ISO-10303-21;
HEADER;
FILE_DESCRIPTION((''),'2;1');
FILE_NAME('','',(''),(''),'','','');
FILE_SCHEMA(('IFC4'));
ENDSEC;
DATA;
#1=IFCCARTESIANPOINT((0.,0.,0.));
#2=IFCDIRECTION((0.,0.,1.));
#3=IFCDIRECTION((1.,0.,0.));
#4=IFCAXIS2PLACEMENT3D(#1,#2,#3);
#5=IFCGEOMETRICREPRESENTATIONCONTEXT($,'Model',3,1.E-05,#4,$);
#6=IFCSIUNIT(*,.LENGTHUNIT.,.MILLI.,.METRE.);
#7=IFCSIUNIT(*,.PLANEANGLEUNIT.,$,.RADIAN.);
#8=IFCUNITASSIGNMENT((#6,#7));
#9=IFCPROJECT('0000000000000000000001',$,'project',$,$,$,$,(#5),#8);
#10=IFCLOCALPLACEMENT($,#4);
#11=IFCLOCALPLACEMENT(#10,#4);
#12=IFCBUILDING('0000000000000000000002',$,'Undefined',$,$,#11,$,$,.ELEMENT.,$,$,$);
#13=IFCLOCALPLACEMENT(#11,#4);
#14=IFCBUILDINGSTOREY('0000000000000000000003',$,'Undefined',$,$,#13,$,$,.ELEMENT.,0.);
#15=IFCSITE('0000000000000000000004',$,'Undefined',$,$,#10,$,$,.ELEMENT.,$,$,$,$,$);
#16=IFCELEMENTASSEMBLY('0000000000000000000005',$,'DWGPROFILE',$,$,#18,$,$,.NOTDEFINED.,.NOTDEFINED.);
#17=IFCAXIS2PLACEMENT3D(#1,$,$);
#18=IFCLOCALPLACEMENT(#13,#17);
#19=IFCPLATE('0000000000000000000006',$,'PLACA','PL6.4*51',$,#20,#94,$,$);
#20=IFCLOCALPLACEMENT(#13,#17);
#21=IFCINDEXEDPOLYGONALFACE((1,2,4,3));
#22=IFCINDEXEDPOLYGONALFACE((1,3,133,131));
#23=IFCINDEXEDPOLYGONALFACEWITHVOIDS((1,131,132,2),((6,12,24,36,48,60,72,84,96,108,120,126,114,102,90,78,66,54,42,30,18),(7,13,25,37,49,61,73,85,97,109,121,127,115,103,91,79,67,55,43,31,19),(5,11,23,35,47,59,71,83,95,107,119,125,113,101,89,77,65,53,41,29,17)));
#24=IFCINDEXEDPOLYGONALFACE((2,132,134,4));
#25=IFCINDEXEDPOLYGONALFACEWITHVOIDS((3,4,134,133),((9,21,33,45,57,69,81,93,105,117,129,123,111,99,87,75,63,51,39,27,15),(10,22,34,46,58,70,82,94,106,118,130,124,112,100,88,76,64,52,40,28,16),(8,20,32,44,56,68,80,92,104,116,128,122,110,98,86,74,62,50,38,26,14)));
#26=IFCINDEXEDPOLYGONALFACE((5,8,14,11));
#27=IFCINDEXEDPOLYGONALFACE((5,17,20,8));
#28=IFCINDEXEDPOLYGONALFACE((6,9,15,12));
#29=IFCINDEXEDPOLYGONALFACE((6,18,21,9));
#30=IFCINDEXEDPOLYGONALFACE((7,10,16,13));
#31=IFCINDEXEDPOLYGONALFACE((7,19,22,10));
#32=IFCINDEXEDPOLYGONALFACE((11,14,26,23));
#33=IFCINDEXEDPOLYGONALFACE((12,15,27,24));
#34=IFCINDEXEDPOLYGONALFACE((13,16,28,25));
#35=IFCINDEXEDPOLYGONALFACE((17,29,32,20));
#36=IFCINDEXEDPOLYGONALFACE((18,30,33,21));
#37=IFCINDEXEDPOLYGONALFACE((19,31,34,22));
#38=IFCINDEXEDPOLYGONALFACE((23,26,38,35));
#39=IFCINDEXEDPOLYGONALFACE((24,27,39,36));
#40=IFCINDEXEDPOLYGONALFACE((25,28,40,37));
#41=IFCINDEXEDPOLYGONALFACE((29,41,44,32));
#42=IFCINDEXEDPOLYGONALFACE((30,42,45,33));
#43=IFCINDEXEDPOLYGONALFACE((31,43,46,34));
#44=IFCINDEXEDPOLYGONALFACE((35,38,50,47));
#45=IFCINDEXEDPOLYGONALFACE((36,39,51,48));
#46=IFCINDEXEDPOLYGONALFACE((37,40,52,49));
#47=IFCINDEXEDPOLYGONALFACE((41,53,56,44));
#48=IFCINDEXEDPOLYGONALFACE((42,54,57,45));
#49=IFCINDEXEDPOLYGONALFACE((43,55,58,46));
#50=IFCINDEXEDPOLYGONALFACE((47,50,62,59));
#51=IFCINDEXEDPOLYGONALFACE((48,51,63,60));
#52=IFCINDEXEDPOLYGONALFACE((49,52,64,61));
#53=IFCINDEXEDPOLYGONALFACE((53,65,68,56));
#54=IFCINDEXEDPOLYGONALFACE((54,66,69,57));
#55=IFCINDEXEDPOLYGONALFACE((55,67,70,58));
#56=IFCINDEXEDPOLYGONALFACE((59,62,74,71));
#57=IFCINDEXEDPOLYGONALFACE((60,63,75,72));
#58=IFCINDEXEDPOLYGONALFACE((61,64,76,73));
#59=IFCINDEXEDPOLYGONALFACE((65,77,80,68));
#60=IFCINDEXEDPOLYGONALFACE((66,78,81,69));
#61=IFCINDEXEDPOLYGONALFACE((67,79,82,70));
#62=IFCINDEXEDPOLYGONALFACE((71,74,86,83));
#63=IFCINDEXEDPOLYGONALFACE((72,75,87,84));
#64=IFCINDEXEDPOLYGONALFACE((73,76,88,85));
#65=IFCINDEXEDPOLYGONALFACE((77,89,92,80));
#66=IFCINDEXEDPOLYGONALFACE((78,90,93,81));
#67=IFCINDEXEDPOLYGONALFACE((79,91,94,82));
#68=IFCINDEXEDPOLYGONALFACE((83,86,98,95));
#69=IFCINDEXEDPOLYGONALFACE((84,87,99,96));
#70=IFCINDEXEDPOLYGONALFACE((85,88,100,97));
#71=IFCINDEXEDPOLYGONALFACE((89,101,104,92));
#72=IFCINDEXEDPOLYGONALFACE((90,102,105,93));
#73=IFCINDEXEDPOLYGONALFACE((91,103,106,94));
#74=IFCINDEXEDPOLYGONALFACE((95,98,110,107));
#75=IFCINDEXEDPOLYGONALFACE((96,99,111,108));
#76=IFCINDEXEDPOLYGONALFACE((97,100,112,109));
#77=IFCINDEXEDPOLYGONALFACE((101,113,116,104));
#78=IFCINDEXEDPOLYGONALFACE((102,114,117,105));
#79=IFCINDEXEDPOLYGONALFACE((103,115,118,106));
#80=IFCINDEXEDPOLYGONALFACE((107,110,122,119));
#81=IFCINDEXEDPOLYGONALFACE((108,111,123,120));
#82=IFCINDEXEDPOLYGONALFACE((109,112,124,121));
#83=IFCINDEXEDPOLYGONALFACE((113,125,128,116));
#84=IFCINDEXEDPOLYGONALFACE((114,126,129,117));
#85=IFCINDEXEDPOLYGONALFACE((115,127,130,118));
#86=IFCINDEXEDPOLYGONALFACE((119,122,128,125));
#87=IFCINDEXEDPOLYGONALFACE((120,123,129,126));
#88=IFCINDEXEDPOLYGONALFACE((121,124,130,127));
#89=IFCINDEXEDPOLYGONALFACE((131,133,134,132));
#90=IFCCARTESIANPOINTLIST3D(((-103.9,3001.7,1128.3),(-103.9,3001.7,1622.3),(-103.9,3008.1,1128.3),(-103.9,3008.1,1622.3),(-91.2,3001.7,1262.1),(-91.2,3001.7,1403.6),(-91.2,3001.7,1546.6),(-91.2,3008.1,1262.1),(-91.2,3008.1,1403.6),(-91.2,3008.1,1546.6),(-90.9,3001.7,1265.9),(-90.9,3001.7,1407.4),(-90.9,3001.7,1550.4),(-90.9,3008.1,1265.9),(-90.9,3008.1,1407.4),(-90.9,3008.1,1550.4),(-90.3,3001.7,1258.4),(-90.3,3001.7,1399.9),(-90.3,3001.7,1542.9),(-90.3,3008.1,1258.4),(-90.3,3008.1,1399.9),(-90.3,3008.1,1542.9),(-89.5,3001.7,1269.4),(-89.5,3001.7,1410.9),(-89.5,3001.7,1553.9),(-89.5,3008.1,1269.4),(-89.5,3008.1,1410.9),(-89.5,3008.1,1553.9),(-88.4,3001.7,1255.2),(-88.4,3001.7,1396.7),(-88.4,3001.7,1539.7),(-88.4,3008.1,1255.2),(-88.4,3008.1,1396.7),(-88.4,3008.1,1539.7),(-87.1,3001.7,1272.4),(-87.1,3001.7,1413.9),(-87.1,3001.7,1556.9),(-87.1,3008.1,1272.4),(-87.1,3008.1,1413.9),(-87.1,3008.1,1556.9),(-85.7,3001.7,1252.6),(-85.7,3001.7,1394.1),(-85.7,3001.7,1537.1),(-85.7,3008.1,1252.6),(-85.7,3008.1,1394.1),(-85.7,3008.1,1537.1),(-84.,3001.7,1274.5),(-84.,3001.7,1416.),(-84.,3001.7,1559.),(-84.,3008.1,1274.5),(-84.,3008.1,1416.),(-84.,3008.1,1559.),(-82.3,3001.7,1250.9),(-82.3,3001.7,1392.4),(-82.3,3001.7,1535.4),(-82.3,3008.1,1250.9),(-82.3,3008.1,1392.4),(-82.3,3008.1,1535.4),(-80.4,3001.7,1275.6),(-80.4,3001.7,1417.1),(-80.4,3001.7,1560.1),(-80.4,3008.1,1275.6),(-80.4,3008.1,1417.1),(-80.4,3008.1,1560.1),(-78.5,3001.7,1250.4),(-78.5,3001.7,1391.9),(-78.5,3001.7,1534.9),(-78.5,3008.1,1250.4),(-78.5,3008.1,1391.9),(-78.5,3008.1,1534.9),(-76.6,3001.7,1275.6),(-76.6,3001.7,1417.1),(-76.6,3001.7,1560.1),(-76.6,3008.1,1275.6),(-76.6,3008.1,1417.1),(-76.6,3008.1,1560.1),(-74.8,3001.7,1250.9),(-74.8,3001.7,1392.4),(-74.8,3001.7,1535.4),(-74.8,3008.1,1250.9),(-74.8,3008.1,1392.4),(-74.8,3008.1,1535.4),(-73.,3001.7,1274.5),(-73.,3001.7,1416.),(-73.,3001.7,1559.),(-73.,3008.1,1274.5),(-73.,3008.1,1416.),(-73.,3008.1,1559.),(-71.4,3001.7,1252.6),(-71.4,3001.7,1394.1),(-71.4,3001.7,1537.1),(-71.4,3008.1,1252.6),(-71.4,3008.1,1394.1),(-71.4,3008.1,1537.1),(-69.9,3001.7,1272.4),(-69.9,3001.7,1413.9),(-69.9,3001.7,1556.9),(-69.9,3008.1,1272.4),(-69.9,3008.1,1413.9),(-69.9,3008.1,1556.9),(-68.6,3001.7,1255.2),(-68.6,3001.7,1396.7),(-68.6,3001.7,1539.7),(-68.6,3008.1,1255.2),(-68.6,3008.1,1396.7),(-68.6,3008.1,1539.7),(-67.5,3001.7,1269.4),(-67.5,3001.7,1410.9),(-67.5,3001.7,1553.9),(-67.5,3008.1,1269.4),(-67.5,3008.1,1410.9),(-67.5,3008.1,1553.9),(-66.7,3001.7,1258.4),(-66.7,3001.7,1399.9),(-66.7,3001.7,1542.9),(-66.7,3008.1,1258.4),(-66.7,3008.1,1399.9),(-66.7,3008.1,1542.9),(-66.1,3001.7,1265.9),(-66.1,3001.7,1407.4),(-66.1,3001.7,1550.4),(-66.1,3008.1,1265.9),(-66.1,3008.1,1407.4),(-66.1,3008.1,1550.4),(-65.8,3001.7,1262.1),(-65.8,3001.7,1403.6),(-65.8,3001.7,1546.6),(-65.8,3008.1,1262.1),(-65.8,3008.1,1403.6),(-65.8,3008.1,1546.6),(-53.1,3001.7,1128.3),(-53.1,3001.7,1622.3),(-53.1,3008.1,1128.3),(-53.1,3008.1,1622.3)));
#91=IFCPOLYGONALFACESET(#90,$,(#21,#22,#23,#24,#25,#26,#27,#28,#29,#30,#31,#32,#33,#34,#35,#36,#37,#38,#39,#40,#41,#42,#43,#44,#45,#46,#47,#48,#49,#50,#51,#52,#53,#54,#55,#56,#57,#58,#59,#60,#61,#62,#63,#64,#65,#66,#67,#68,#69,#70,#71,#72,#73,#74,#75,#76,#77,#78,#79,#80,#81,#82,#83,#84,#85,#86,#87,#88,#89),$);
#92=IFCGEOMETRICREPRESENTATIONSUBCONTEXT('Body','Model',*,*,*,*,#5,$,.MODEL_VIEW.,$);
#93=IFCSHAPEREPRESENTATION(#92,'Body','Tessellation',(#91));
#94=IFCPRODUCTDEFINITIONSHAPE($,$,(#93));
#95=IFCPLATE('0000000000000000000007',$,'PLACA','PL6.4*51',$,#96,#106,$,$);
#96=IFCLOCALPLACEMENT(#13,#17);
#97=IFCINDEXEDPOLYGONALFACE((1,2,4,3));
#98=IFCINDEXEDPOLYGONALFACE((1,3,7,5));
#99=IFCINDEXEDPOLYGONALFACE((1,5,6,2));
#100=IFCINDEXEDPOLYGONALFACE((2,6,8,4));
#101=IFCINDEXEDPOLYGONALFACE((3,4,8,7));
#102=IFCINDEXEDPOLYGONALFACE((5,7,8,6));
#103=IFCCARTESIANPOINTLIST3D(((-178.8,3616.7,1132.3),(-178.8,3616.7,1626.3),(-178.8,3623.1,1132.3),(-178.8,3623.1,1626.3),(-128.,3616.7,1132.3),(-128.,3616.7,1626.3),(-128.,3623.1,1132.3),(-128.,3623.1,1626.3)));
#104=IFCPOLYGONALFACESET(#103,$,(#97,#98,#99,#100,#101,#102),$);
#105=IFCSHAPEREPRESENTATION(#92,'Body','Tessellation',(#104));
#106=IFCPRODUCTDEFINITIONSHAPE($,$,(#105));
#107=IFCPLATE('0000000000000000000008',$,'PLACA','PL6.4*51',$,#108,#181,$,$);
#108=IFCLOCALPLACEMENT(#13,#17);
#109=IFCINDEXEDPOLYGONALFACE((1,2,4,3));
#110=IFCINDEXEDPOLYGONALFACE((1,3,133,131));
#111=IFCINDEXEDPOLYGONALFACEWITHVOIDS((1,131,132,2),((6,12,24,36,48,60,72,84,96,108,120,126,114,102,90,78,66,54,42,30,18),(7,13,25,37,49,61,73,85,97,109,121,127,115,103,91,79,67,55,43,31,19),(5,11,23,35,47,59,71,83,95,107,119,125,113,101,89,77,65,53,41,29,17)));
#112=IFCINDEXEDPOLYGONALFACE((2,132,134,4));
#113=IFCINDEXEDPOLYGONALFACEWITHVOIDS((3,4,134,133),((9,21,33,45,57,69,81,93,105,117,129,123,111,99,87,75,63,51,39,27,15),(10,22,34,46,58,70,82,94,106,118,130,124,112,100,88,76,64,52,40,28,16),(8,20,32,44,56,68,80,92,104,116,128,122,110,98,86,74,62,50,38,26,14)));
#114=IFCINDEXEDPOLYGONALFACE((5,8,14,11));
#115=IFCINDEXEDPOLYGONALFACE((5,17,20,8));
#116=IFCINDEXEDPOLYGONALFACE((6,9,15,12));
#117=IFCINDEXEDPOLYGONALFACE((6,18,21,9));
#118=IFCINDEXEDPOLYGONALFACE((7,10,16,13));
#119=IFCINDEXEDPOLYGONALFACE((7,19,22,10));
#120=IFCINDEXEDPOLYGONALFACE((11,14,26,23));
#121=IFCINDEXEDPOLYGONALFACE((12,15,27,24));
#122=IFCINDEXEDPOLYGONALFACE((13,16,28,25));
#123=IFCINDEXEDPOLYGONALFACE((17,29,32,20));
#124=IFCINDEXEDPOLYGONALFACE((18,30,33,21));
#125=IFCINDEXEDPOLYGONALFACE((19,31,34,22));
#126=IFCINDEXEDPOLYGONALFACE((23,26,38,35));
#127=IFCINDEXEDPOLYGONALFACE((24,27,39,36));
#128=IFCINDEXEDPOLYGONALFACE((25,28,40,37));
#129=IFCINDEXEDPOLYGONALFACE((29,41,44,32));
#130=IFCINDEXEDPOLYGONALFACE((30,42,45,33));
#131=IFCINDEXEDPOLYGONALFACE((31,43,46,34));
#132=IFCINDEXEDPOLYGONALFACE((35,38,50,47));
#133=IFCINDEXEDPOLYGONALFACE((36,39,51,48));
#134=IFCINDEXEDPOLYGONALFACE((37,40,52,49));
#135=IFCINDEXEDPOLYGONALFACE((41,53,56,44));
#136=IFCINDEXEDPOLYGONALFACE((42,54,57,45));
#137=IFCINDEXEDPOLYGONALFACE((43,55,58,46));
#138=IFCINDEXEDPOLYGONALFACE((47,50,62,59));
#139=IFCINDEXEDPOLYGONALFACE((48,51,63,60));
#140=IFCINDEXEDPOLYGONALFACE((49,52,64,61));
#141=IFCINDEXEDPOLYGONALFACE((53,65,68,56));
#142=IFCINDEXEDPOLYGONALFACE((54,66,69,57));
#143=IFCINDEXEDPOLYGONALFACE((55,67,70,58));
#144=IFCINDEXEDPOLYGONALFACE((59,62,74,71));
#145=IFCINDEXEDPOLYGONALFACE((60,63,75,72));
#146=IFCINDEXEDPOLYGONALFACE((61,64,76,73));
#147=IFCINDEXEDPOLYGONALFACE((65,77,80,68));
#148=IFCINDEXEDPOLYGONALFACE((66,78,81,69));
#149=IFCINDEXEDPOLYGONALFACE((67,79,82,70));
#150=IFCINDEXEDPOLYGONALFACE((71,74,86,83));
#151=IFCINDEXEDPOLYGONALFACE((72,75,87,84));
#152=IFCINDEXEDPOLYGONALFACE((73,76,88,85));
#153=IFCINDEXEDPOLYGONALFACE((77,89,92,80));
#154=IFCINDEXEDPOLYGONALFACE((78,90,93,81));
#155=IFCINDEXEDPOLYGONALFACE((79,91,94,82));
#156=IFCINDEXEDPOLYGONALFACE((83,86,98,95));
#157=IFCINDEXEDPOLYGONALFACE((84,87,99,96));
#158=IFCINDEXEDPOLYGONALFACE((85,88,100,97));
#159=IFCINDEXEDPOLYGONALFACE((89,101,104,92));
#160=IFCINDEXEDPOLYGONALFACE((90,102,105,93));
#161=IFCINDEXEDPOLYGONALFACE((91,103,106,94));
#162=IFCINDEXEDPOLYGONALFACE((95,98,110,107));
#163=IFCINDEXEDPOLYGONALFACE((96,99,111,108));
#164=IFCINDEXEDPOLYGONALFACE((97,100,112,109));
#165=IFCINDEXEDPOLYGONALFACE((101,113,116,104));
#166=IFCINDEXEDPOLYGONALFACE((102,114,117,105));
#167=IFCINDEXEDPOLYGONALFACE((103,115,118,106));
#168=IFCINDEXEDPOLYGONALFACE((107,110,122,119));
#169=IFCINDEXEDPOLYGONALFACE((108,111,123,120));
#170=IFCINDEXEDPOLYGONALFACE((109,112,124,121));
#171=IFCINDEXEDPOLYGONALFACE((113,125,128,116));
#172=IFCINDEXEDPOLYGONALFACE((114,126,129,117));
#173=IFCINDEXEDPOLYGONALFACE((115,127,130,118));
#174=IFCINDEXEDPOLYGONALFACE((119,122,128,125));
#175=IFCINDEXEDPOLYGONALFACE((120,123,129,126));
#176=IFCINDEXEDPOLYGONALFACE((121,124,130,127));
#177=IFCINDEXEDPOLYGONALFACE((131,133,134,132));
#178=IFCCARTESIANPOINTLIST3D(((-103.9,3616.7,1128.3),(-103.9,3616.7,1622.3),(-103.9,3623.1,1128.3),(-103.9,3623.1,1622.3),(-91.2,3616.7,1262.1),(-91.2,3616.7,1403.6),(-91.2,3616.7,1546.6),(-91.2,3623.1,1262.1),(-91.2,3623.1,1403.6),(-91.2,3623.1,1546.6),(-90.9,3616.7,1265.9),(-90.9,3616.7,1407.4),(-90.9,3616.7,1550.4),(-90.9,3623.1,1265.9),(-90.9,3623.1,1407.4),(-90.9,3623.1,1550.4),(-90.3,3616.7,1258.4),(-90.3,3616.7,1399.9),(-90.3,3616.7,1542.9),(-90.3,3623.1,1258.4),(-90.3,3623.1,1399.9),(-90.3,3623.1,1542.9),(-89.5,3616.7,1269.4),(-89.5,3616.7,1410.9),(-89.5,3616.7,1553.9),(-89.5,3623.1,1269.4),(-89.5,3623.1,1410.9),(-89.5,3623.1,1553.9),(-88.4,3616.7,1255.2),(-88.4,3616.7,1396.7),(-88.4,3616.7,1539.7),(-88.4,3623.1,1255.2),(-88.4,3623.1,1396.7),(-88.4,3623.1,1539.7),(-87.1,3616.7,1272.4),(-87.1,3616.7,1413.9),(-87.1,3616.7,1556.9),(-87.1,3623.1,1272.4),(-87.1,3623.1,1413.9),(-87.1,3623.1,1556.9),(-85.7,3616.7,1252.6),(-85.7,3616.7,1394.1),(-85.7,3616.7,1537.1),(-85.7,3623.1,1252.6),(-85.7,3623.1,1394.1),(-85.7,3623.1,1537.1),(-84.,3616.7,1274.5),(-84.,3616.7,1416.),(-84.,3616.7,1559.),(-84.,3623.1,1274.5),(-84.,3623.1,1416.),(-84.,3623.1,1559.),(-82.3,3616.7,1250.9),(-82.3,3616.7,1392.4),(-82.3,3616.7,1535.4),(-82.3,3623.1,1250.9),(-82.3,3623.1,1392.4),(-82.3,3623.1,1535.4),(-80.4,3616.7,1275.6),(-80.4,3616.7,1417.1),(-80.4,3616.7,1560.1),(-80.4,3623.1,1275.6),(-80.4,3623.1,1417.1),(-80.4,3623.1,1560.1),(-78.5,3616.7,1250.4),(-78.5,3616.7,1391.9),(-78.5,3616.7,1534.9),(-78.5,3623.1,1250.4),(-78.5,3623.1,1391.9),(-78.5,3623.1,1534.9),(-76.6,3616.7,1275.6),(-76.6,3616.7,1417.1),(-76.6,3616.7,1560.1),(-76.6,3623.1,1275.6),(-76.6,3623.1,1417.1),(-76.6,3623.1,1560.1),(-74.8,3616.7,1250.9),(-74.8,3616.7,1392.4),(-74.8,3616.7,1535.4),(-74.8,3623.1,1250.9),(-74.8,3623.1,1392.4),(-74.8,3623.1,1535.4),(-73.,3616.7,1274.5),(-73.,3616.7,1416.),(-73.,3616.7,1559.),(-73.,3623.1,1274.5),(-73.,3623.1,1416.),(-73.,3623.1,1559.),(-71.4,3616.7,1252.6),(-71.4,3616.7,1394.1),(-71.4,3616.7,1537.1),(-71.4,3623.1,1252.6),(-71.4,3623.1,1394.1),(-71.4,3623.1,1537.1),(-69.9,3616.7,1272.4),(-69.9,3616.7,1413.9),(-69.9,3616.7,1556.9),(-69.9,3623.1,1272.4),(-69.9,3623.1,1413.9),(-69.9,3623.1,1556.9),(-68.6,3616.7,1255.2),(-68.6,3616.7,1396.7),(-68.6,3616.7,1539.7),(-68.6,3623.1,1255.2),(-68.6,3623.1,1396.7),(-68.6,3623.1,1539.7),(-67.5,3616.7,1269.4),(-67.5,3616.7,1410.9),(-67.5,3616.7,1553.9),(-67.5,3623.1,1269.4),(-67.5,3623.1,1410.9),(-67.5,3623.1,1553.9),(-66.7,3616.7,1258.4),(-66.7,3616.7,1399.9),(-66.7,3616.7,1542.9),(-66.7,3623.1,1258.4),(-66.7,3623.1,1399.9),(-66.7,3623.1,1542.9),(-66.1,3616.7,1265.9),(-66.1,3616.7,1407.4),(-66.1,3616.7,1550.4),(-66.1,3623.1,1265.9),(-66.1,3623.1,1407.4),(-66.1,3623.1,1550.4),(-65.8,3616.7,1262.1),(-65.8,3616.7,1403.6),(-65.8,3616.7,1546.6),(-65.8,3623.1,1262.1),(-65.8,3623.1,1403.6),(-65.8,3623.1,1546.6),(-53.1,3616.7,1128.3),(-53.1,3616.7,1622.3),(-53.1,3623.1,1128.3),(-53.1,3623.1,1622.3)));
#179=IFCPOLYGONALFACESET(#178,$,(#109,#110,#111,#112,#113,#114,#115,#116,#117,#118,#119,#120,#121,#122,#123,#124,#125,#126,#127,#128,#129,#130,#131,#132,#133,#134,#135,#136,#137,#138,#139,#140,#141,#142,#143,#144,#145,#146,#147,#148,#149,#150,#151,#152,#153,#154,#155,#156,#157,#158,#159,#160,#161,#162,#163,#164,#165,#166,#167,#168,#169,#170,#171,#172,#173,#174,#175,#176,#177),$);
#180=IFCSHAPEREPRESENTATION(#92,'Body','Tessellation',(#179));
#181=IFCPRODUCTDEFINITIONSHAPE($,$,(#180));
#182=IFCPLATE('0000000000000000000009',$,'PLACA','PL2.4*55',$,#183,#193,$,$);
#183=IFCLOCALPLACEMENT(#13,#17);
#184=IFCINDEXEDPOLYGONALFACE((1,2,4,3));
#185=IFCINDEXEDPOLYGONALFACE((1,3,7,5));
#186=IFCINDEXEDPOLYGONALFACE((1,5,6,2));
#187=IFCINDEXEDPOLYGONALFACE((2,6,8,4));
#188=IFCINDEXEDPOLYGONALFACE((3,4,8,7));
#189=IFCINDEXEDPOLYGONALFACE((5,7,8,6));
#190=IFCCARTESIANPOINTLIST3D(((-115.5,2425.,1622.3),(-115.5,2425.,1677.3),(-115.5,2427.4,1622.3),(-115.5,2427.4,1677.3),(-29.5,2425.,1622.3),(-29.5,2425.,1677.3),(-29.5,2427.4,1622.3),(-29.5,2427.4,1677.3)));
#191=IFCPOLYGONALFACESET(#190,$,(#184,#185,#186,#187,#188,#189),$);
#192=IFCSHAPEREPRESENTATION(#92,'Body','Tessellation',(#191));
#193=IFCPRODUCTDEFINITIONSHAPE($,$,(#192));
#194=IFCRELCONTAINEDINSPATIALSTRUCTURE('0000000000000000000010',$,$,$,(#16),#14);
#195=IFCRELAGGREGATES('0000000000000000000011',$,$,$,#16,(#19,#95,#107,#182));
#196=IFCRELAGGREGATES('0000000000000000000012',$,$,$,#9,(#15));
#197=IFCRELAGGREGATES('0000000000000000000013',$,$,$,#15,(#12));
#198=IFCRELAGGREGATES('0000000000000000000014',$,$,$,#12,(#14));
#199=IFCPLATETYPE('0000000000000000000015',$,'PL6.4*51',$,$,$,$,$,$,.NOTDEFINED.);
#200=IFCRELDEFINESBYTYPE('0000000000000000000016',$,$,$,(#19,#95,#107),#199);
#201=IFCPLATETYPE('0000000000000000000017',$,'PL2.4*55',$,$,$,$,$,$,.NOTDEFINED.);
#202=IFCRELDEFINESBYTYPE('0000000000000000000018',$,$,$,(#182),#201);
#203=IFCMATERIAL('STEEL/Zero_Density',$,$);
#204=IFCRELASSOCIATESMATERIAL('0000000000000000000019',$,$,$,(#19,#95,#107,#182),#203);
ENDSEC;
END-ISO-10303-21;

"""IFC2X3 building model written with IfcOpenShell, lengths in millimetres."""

from ifc_helpers import new_model, si_unit, frame, origin_with_axes, origin_2d_with_axis, place, context, subcontext, project, spatial, polyline, circle, outline, extrude, boolean, material, type_object, element, aggregate, save


model = new_model("IFC2X3")

# Units and contexts
model_context = context("Model", 3, precision=1e-05, world=origin_with_axes())
body_context = subcontext(model_context, "Body", "Model", "MODEL_VIEW")
ifc_project = project(units=[si_unit("LENGTHUNIT", "METRE", prefix="MILLI"), si_unit("PLANEANGLEUNIT", "RADIAN")], contexts=[model_context])

# Site, building, storey
site_placement = place(None, origin_with_axes())
site = spatial("IfcSite", under=ifc_project, at=site_placement, Name="Undefined", CompositionType="ELEMENT")
building_placement = place(site_placement, origin_with_axes())
building = spatial("IfcBuilding", under=site, at=building_placement, Name="Undefined", CompositionType="ELEMENT")
storey_placement = place(building_placement, origin_with_axes())
storey = spatial("IfcBuildingStorey", under=building, at=storey_placement, Name="Undefined", CompositionType="ELEMENT", Elevation=0.0)

# Element assembly, plates
assembly_1_placement = place(storey_placement, origin_with_axes())
assembly_1 = element("IfcElementAssembly", 1, at=assembly_1_placement, inside=storey, Name="DWGPROFILE", AssemblyPlace="NOTDEFINED", PredefinedType="NOTDEFINED")
ifc_material_1 = material(Name="STEEL/Zero_Density")
plate_type_1 = type_object("IfcPlateType", Name="PL6.4*51", PredefinedType="NOTDEFINED")
plate_1_placement = place(assembly_1_placement, frame((-53.1, 3004.9, 1622.3), z_axis=(0.0, -1.0, 0.0), x_axis=(-1.0, 0.0, 0.0)))
plate_1 = element("IfcPlate", 2, at=plate_1_placement, type_object=plate_type_1, material=ifc_material_1, Name="PLACA", Description="PL6.4*51", context=body_context, shape_type="CSG", body=[
    boolean("DIFFERENCE", boolean("DIFFERENCE", boolean("DIFFERENCE", extrude(outline(polyline([(0.0, 0.0), (50.8, 0.0), (50.8, 494.0), (0.0, 494.0), (0.0, 0.0)])), frame((0.0, 0.0, -3.2), z_axis=(0.0, 0.0, 1.0), x_axis=(1.0, 0.0, 0.0)), (0.0, 0.0, 1.0), 6.4), extrude(circle(Radius=12.7, at=origin_2d_with_axis()), frame((25.4, 74.7, -100.0), z_axis=(0.0, 0.0, 1.0), x_axis=(0.0, 1.0, 0.0)), (0.0, 0.0, 1.0), 200.0)), extrude(circle(Radius=12.7, at=origin_2d_with_axis()), frame((25.4, 217.7, -100.0), z_axis=(0.0, 0.0, 1.0), x_axis=(0.0, 1.0, 0.0)), (0.0, 0.0, 1.0), 200.0)), extrude(circle(Radius=12.7, at=origin_2d_with_axis()), frame((25.4, 359.2, -100.0), z_axis=(0.0, 0.0, 1.0), x_axis=(0.0, 1.0, 0.0)), (0.0, 0.0, 1.0), 200.0)),
])
plate_2_placement = place(assembly_1_placement, frame((-128.0, 3619.9, 1626.3), z_axis=(0.0, -1.0, 0.0), x_axis=(-1.0, 0.0, 0.0)))
plate_2 = element("IfcPlate", 3, at=plate_2_placement, type_object=plate_type_1, material=ifc_material_1, Name="PLACA", Description="PL6.4*51", context=body_context, shape_type="SweptSolid", body=[
    extrude(outline(polyline([(0.0, 0.0), (50.8, 0.0), (50.8, 494.0), (0.0, 494.0), (0.0, 0.0)])), frame((0.0, 0.0, -3.2), z_axis=(0.0, 0.0, 1.0), x_axis=(1.0, 0.0, 0.0)), (0.0, 0.0, 1.0), 6.4),
])
plate_3_placement = place(assembly_1_placement, frame((-53.1, 3619.9, 1622.3), z_axis=(0.0, -1.0, 0.0), x_axis=(-1.0, 0.0, 0.0)))
plate_3 = element("IfcPlate", 4, at=plate_3_placement, type_object=plate_type_1, material=ifc_material_1, Name="PLACA", Description="PL6.4*51", context=body_context, shape_type="CSG", body=[
    boolean("DIFFERENCE", boolean("DIFFERENCE", boolean("DIFFERENCE", extrude(outline(polyline([(0.0, 0.0), (50.8, 0.0), (50.8, 494.0), (0.0, 494.0), (0.0, 0.0)])), frame((0.0, 0.0, -3.2), z_axis=(0.0, 0.0, 1.0), x_axis=(1.0, 0.0, 0.0)), (0.0, 0.0, 1.0), 6.4), extrude(circle(Radius=12.7, at=origin_2d_with_axis()), frame((25.4, 74.7, -100.0), z_axis=(0.0, 0.0, 1.0), x_axis=(0.0, 1.0, 0.0)), (0.0, 0.0, 1.0), 200.0)), extrude(circle(Radius=12.7, at=origin_2d_with_axis()), frame((25.4, 217.7, -100.0), z_axis=(0.0, 0.0, 1.0), x_axis=(0.0, 1.0, 0.0)), (0.0, 0.0, 1.0), 200.0)), extrude(circle(Radius=12.7, at=origin_2d_with_axis()), frame((25.4, 359.2, -100.0), z_axis=(0.0, 0.0, 1.0), x_axis=(0.0, 1.0, 0.0)), (0.0, 0.0, 1.0), 200.0)),
])
plate_type_2 = type_object("IfcPlateType", Name="PL2.4*55", PredefinedType="NOTDEFINED")
plate_4_placement = place(assembly_1_placement, frame((-29.5, 2426.2, 1677.3), z_axis=(0.0, -1.0, 0.0), x_axis=(-1.0, 0.0, 0.0)))
plate_4 = element("IfcPlate", 5, at=plate_4_placement, type_object=plate_type_2, material=ifc_material_1, Name="PLACA", Description="PL2.4*55", context=body_context, shape_type="SweptSolid", body=[
    extrude(outline(polyline([(0.0, 0.0), (86.0, 0.0), (86.0, 55.0), (0.0, 55.0), (0.0, 0.0)])), frame((0.0, 0.0, -1.2), z_axis=(0.0, 0.0, 1.0), x_axis=(1.0, 0.0, 0.0)), (0.0, 0.0, 1.0), 2.4),
])
aggregate(assembly_1, [plate_1, plate_2, plate_3, plate_4])

save(model, "model.ifc")
